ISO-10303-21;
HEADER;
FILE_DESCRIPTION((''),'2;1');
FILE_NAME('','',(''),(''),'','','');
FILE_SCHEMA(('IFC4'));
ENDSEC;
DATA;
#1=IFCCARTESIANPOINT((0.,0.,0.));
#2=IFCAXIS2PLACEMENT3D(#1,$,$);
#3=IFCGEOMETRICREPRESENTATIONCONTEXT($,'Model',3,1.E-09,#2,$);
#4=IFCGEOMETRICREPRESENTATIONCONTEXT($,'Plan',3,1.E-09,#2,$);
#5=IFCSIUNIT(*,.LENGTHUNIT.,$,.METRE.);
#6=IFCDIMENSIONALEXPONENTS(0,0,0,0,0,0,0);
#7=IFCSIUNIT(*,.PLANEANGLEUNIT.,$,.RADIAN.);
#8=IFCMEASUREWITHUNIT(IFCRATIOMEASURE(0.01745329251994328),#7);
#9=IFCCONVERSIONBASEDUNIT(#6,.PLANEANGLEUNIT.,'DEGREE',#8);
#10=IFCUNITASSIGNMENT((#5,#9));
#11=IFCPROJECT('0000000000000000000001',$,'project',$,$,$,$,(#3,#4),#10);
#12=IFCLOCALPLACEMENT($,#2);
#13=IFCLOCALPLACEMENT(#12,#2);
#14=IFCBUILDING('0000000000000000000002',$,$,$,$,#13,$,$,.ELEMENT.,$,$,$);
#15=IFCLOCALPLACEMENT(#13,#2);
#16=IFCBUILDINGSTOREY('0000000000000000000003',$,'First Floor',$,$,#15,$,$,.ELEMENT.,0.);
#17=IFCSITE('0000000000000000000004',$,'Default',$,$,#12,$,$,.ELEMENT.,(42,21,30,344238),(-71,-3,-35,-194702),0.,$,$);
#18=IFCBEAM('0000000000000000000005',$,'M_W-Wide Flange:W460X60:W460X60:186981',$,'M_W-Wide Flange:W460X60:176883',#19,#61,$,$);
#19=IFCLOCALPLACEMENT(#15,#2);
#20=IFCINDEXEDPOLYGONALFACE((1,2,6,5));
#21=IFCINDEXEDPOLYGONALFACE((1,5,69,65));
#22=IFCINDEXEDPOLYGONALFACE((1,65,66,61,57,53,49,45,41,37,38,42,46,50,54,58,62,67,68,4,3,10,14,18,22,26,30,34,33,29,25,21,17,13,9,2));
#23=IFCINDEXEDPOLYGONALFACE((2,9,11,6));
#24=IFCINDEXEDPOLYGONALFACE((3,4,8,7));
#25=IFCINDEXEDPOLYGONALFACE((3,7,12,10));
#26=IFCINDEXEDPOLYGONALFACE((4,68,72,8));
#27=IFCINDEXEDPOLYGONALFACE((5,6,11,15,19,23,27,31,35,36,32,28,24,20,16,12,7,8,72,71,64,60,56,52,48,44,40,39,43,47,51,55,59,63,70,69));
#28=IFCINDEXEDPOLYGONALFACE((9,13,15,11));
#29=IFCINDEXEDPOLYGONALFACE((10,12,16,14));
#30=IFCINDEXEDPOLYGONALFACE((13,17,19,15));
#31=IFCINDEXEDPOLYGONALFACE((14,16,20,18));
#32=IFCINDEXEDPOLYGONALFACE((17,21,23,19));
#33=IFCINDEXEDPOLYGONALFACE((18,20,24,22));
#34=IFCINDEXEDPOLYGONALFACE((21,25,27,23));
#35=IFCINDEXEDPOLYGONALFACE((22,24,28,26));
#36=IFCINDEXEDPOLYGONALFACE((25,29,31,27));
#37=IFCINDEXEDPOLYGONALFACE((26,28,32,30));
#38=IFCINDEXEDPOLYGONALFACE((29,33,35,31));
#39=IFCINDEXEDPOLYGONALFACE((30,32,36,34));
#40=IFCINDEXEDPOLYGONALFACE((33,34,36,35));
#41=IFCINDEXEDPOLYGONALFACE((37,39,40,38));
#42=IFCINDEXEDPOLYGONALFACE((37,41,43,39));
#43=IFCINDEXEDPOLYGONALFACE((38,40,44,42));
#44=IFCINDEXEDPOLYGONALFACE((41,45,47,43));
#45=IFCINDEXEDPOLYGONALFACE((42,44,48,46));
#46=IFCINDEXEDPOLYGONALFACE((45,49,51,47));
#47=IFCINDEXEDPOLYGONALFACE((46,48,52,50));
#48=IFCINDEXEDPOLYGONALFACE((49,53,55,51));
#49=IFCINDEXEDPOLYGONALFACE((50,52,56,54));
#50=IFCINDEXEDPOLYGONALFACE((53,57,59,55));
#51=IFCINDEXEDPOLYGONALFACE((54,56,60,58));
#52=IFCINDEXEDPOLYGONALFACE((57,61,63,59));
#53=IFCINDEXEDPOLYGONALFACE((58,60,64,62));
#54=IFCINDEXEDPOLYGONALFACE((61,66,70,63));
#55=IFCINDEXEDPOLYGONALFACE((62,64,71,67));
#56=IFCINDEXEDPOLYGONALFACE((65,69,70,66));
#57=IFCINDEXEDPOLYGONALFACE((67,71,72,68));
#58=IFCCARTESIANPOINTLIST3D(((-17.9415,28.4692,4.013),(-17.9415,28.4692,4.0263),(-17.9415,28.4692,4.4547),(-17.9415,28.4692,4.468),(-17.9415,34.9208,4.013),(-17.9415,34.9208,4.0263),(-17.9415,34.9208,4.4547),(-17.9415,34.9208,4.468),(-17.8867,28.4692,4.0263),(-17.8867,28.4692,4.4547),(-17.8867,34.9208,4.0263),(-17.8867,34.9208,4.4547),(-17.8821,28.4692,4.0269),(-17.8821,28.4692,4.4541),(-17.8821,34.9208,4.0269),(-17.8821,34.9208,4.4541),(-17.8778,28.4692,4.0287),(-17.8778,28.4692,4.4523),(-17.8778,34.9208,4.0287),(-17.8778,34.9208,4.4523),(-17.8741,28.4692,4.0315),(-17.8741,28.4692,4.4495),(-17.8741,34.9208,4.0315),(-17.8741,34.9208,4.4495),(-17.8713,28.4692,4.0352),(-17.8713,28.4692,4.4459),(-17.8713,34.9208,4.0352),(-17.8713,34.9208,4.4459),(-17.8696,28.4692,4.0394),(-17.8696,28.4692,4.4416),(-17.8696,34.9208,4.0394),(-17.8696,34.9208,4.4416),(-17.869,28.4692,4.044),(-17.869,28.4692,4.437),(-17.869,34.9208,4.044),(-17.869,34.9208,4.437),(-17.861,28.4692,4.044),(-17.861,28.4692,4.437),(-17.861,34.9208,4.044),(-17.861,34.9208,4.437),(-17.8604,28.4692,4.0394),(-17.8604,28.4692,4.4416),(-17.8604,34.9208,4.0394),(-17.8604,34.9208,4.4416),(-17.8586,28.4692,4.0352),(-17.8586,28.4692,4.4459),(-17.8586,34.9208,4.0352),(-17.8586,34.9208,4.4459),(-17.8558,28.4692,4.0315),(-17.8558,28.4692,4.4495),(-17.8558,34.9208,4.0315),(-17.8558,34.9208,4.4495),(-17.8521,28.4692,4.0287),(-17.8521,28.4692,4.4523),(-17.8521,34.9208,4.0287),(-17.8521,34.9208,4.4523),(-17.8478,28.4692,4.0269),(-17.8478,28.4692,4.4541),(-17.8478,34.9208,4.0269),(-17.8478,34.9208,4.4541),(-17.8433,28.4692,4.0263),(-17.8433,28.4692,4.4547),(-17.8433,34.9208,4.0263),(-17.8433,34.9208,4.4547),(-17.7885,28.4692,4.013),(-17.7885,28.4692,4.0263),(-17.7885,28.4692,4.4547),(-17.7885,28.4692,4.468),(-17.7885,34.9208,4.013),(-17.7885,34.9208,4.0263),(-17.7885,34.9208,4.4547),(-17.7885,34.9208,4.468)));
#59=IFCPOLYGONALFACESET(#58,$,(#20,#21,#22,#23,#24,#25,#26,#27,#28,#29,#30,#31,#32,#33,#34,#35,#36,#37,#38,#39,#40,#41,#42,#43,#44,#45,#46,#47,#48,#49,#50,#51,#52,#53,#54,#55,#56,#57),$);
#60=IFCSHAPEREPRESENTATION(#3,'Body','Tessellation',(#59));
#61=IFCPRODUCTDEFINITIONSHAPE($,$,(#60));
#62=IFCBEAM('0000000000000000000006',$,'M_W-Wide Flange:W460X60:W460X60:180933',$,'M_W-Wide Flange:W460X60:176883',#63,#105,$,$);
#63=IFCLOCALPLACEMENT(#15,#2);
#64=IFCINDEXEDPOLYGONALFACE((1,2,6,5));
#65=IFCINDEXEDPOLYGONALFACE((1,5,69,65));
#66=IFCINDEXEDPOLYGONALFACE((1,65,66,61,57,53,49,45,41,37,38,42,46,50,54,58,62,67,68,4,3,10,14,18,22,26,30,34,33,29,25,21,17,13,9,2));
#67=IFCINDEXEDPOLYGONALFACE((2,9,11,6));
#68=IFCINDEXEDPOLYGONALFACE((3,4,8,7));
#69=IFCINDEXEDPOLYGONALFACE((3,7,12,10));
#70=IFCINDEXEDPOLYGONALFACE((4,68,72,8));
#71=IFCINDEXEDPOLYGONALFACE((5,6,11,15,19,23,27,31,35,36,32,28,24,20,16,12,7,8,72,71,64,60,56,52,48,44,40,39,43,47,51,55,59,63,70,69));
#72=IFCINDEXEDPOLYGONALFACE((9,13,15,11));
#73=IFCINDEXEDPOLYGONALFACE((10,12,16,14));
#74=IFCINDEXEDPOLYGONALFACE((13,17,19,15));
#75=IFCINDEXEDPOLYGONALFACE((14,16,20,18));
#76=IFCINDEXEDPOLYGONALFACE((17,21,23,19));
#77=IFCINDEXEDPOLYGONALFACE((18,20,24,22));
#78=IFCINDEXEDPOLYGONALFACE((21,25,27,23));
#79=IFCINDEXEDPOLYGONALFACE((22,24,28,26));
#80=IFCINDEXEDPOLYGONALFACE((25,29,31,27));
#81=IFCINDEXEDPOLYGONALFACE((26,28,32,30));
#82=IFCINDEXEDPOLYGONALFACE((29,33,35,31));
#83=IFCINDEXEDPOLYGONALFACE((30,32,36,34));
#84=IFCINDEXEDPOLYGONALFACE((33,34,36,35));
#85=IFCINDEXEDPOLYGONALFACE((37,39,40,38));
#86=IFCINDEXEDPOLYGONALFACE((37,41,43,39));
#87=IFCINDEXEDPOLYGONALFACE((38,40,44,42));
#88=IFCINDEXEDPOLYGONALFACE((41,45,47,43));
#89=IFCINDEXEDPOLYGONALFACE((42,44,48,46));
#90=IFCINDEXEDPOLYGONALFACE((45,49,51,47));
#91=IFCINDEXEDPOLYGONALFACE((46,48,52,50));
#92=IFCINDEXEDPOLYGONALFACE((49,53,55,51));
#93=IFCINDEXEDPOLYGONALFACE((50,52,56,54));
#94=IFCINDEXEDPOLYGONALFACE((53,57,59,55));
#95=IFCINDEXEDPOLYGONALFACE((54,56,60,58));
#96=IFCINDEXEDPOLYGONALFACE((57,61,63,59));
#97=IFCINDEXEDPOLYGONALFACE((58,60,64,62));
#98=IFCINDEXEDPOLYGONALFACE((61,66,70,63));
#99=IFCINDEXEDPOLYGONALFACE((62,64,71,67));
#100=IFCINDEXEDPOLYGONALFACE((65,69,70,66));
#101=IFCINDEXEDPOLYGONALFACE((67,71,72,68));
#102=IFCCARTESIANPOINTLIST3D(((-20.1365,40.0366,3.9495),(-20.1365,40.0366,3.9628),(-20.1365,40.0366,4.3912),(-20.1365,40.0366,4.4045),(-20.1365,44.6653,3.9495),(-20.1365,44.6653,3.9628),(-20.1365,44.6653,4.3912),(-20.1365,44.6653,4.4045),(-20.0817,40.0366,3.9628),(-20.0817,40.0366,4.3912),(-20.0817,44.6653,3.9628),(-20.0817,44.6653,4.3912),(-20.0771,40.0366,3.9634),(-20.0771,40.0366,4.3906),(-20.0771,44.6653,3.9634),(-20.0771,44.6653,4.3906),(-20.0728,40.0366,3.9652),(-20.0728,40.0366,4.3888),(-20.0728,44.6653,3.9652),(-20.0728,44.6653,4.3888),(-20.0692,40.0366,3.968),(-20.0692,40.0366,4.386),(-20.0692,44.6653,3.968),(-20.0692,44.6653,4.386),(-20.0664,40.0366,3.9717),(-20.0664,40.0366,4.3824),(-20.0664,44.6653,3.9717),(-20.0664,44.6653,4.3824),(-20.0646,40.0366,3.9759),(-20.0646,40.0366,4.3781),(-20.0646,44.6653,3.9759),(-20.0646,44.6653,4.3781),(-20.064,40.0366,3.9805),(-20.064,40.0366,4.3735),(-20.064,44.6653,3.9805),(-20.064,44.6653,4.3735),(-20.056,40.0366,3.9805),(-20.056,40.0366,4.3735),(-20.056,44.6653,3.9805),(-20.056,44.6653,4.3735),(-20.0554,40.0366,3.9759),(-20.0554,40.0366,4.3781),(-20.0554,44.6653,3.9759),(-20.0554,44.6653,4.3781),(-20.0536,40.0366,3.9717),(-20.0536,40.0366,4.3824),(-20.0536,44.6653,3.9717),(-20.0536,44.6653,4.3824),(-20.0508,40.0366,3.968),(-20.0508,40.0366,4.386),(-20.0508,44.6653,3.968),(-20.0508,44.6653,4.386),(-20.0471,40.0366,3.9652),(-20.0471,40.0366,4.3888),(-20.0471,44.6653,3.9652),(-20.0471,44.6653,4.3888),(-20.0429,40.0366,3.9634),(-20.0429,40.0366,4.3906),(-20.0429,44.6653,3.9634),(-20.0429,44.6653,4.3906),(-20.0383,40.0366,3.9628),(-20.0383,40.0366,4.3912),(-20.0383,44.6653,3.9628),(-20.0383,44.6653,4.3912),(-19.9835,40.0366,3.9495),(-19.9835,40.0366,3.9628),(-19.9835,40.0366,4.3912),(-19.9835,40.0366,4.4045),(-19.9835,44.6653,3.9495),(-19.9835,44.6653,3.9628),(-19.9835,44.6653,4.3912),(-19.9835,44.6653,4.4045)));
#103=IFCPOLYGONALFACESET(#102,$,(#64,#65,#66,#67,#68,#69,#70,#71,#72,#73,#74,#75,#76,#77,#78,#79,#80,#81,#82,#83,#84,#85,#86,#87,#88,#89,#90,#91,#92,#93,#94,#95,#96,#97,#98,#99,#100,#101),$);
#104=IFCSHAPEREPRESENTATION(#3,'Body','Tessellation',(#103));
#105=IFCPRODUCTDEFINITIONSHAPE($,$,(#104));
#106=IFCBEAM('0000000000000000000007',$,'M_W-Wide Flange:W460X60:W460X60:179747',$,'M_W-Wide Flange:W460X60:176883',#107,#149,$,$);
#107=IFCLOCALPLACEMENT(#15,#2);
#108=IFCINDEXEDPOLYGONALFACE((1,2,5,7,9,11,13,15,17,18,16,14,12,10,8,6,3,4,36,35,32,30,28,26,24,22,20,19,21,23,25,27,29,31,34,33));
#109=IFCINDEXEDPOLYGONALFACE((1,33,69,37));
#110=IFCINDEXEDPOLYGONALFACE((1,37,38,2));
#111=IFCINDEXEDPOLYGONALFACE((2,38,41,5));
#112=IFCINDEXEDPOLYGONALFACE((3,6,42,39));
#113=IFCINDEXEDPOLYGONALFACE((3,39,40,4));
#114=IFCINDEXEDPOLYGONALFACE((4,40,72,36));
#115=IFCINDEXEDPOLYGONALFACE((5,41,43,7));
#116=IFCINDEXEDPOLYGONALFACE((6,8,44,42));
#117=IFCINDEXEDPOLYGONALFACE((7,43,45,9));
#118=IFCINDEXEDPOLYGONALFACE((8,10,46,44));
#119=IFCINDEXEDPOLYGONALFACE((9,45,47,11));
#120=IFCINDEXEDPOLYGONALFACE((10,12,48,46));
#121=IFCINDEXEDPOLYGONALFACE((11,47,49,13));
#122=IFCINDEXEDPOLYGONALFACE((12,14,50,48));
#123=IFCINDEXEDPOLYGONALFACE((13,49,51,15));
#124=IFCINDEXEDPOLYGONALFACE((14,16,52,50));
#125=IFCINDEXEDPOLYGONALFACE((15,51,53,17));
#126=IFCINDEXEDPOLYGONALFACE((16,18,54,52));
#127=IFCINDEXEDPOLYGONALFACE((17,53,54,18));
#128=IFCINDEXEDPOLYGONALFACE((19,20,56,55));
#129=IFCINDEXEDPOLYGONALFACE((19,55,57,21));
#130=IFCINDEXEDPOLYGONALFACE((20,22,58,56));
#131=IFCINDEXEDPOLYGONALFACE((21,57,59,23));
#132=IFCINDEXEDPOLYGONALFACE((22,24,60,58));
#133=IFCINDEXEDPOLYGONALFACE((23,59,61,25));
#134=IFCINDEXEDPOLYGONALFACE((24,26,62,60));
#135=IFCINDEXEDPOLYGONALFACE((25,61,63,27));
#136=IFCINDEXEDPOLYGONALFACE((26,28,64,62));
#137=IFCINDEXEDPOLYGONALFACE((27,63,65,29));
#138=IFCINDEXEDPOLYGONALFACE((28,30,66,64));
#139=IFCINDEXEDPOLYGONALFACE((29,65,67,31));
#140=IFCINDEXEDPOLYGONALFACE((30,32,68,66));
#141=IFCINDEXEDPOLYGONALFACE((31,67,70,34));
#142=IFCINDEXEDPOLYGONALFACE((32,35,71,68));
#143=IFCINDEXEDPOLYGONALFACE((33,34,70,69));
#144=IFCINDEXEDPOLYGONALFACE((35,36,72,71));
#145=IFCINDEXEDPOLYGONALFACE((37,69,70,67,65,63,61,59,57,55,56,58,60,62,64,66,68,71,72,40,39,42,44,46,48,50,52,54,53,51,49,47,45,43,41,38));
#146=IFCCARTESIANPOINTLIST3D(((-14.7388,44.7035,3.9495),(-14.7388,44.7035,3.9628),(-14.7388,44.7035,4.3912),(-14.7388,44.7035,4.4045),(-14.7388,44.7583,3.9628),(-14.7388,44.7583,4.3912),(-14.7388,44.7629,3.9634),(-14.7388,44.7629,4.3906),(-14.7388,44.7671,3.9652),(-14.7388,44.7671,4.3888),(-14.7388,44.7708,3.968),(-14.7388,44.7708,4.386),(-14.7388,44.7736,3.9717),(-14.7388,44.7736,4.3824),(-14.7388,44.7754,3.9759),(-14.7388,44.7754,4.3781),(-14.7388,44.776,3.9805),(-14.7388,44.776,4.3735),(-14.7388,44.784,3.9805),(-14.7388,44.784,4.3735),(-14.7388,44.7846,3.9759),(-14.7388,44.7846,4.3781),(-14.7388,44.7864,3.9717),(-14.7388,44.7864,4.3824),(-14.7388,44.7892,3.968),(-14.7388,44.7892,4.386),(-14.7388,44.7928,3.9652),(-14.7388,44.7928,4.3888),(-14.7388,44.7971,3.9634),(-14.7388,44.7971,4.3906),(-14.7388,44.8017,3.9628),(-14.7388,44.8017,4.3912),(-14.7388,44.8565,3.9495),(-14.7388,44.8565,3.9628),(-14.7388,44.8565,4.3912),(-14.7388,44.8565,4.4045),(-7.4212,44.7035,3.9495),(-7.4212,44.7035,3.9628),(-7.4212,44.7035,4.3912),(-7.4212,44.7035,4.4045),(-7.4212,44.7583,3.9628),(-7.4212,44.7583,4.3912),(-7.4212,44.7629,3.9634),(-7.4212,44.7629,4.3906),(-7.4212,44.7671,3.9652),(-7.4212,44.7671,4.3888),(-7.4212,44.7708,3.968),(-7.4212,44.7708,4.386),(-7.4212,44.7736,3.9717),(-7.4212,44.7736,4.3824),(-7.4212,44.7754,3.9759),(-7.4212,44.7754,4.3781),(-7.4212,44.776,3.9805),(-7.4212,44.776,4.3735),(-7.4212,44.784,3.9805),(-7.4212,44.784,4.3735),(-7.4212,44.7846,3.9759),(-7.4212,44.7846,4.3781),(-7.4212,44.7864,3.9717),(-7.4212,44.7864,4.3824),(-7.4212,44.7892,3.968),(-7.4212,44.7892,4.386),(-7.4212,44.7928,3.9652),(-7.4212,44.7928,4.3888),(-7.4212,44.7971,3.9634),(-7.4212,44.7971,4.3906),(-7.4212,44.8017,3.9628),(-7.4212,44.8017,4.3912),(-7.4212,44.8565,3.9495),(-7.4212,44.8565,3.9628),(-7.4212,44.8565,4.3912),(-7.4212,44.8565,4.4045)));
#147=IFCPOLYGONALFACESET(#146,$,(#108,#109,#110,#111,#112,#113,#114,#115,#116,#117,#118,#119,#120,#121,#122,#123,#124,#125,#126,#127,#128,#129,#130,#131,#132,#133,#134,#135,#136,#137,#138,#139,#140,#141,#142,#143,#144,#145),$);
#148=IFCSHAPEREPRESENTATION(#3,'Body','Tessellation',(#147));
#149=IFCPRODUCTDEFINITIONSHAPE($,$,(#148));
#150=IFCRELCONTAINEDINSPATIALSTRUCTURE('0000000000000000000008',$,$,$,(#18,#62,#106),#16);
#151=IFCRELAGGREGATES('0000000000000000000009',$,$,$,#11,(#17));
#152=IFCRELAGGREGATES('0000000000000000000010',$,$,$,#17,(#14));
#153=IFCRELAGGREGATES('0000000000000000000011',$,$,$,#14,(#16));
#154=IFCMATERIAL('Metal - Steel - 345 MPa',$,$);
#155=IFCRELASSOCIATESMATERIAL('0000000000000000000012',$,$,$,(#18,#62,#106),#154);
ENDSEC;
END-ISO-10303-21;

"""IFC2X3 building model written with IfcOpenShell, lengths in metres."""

from ifc_helpers import new_model, entity, si_unit, converted_unit, frame, frame_2d, origin, place, context, project, spatial, polyline, circle_curve, parameter, trimmed, segment, composite_curve, outline, extrude, material, element, save


model = new_model("IFC2X3")

# Units and contexts
model_context = context("Model", 3, precision=1e-09, world=origin())
plan_context = context("Plan", 3, precision=1e-09, world=origin())
ifc_project = project(units=[si_unit("LENGTHUNIT", "METRE"), converted_unit("PLANEANGLEUNIT", "DEGREE", entity("IfcRatioMeasure", 0.01745329251994328), si_unit("PLANEANGLEUNIT", "RADIAN"), dimensions=[0, 0, 0, 0, 0, 0, 0])], contexts=[model_context, plan_context])

# Site, building, storey
site_placement = place(None, origin())
site = spatial("IfcSite", under=ifc_project, at=site_placement, Name="Default", CompositionType="ELEMENT", RefLatitude=(42, 21, 30, 344238), RefLongitude=(-71, -3, -35, -194702), RefElevation=0.0)
building_placement = place(site_placement, origin())
building = spatial("IfcBuilding", under=site, at=building_placement, CompositionType="ELEMENT")
storey_placement = place(building_placement, origin())
storey = spatial("IfcBuildingStorey", under=building, at=storey_placement, Name="First Floor", CompositionType="ELEMENT", Elevation=0.0)

# Shared definitions
ifc_material = material(Name="Metal - Steel - 345 MPa")

# Beams
beam_1_placement = place(storey_placement, frame((-17.865, 28.528, 4.468)))
element("IfcBeam", 1, at=beam_1_placement, inside=storey, material=ifc_material, Name="M_W-Wide Flange:W460X60:W460X60:186981", ObjectType="M_W-Wide Flange:W460X60:176883", context=model_context, shape_type="SweptSolid", body=[
    extrude(outline(composite_curve([segment(polyline([(-0.0765, -0.2142), (-0.0765, -0.2275)]), True, "CONTINUOUS"), segment(polyline([(-0.0765, -0.2275), (0.0765, -0.2275)]), True, "CONTINUOUS"), segment(polyline([(0.0765, -0.2275), (0.0765, -0.2142)]), True, "CONTINUOUS"), segment(polyline([(0.0765, -0.2142), (0.0217, -0.2142)]), True, "CONTINUOUS"), segment(trimmed(circle_curve(frame_2d((0.0217, -0.1965), x_axis=(1.0, 0.0)), 0.0177), [parameter(180.0)], [parameter(270.0)], True, "PARAMETER"), False, "CONTINUOUS"), segment(polyline([(0.004, -0.1965), (0.004, 0.1965)]), True, "CONTINUOUS"), segment(trimmed(circle_curve(frame_2d((0.0217, 0.1965), x_axis=(1.0, 0.0)), 0.0177), [parameter(90.0)], [parameter(180.0)], True, "PARAMETER"), False, "CONTINUOUS"), segment(polyline([(0.0217, 0.2142), (0.0765, 0.2142)]), True, "CONTINUOUS"), segment(polyline([(0.0765, 0.2142), (0.0765, 0.2275)]), True, "CONTINUOUS"), segment(polyline([(0.0765, 0.2275), (-0.0765, 0.2275)]), True, "CONTINUOUS"), segment(polyline([(-0.0765, 0.2275), (-0.0765, 0.2142)]), True, "CONTINUOUS"), segment(polyline([(-0.0765, 0.2142), (-0.0217, 0.2142)]), True, "CONTINUOUS"), segment(trimmed(circle_curve(frame_2d((-0.0217, 0.1965), x_axis=(1.0, 0.0)), 0.0177), [parameter(360.0)], [parameter(90.0)], True, "PARAMETER"), False, "CONTINUOUS"), segment(polyline([(-0.004, 0.1965), (-0.004, -0.1965)]), True, "CONTINUOUS"), segment(trimmed(circle_curve(frame_2d((-0.0217, -0.1965), x_axis=(1.0, 0.0)), 0.0177), [parameter(270.0)], [parameter(0.0)], True, "PARAMETER"), False, "CONTINUOUS"), segment(polyline([(-0.0217, -0.2142), (-0.0765, -0.2142)]), True, "CONTINUOUS")], self_intersect=False)), frame((0.0, -0.0588, -0.2275), z_axis=(0.0, -1.0, 0.0), x_axis=(1.0, 0.0, 0.0)), (0.0, 0.0, -1.0), 6.4516),
])
beam_2_placement = place(storey_placement, frame((-20.06, 44.7828, 4.4045), z_axis=(0.0, 0.0, 1.0), x_axis=(-1.0, 0.0, 0.0)))
element("IfcBeam", 2, at=beam_2_placement, inside=storey, material=ifc_material, Name="M_W-Wide Flange:W460X60:W460X60:180933", ObjectType="M_W-Wide Flange:W460X60:176883", context=model_context, shape_type="SweptSolid", body=[
    extrude(outline(composite_curve([segment(polyline([(0.2142, -0.0765), (0.2275, -0.0765)]), True, "CONTINUOUS"), segment(polyline([(0.2275, -0.0765), (0.2275, 0.0765)]), True, "CONTINUOUS"), segment(polyline([(0.2275, 0.0765), (0.2142, 0.0765)]), True, "CONTINUOUS"), segment(polyline([(0.2142, 0.0765), (0.2142, 0.0217)]), True, "CONTINUOUS"), segment(trimmed(circle_curve(frame_2d((0.1965, 0.0217), x_axis=(1.0, 0.0)), 0.0177), [parameter(270.0)], [parameter(360.0)], True, "PARAMETER"), False, "CONTINUOUS"), segment(polyline([(0.1965, 0.004), (-0.1965, 0.004)]), True, "CONTINUOUS"), segment(trimmed(circle_curve(frame_2d((-0.1965, 0.0217), x_axis=(0.0, -1.0)), 0.0177), [parameter(270.0)], [parameter(360.0)], True, "PARAMETER"), False, "CONTINUOUS"), segment(polyline([(-0.2142, 0.0217), (-0.2142, 0.0765)]), True, "CONTINUOUS"), segment(polyline([(-0.2142, 0.0765), (-0.2275, 0.0765)]), True, "CONTINUOUS"), segment(polyline([(-0.2275, 0.0765), (-0.2275, -0.0765)]), True, "CONTINUOUS"), segment(polyline([(-0.2275, -0.0765), (-0.2142, -0.0765)]), True, "CONTINUOUS"), segment(polyline([(-0.2142, -0.0765), (-0.2142, -0.0217)]), True, "CONTINUOUS"), segment(trimmed(circle_curve(frame_2d((-0.1965, -0.0217), x_axis=(-1.0, 0.0)), 0.0177), [parameter(270.0)], [parameter(360.0)], True, "PARAMETER"), False, "CONTINUOUS"), segment(polyline([(-0.1965, -0.004), (0.1965, -0.004)]), True, "CONTINUOUS"), segment(trimmed(circle_curve(frame_2d((0.1965, -0.0217), x_axis=(0.0, 1.0)), 0.0177), [parameter(270.0)], [parameter(0.0)], True, "PARAMETER"), False, "CONTINUOUS"), segment(polyline([(0.2142, -0.0217), (0.2142, -0.0765)]), True, "CONTINUOUS")], self_intersect=False)), frame((0.0, 4.7462, -0.2275), z_axis=(0.0, -1.0, 0.0), x_axis=(0.0, 0.0, -1.0)), (0.0, 0.0, 1.0), 4.6287),
])
beam_3_placement = place(storey_placement, frame((-14.8818, 44.78, 4.4045), z_axis=(0.0, 0.0, 1.0), x_axis=(0.0, -1.0, 0.0)))
element("IfcBeam", 3, at=beam_3_placement, inside=storey, material=ifc_material, Name="M_W-Wide Flange:W460X60:W460X60:179747", ObjectType="M_W-Wide Flange:W460X60:176883", context=model_context, shape_type="SweptSolid", body=[
    extrude(outline(composite_curve([segment(polyline([(-0.0765, -0.2142), (-0.0765, -0.2275)]), True, "CONTINUOUS"), segment(polyline([(-0.0765, -0.2275), (0.0765, -0.2275)]), True, "CONTINUOUS"), segment(polyline([(0.0765, -0.2275), (0.0765, -0.2142)]), True, "CONTINUOUS"), segment(polyline([(0.0765, -0.2142), (0.0217, -0.2142)]), True, "CONTINUOUS"), segment(trimmed(circle_curve(frame_2d((0.0217, -0.1965), x_axis=(0.0, -1.0)), 0.0177), [parameter(270.0)], [parameter(360.0)], True, "PARAMETER"), False, "CONTINUOUS"), segment(polyline([(0.004, -0.1965), (0.004, 0.1965)]), True, "CONTINUOUS"), segment(trimmed(circle_curve(frame_2d((0.0217, 0.1965), x_axis=(-1.0, 0.0)), 0.0177), [parameter(270.0)], [parameter(360.0)], True, "PARAMETER"), False, "CONTINUOUS"), segment(polyline([(0.0217, 0.2142), (0.0765, 0.2142)]), True, "CONTINUOUS"), segment(polyline([(0.0765, 0.2142), (0.0765, 0.2275)]), True, "CONTINUOUS"), segment(polyline([(0.0765, 0.2275), (-0.0765, 0.2275)]), True, "CONTINUOUS"), segment(polyline([(-0.0765, 0.2275), (-0.0765, 0.2142)]), True, "CONTINUOUS"), segment(polyline([(-0.0765, 0.2142), (-0.0217, 0.2142)]), True, "CONTINUOUS"), segment(trimmed(circle_curve(frame_2d((-0.0217, 0.1965), x_axis=(0.0, 1.0)), 0.0177), [parameter(270.0)], [parameter(360.0)], True, "PARAMETER"), False, "CONTINUOUS"), segment(polyline([(-0.004, 0.1965), (-0.004, -0.1965)]), True, "CONTINUOUS"), segment(trimmed(circle_curve(frame_2d((-0.0217, -0.1965), x_axis=(1.0, 0.0)), 0.0177), [parameter(270.0)], [parameter(0.0)], True, "PARAMETER"), False, "CONTINUOUS"), segment(polyline([(-0.0217, -0.2142), (-0.0765, -0.2142)]), True, "CONTINUOUS")], self_intersect=False)), frame((0.0, 0.143, -0.2275), z_axis=(0.0, -1.0, 0.0), x_axis=(1.0, 0.0, 0.0)), (0.0, 0.0, -1.0), 7.3176),
])

save(model, "model.ifc")
